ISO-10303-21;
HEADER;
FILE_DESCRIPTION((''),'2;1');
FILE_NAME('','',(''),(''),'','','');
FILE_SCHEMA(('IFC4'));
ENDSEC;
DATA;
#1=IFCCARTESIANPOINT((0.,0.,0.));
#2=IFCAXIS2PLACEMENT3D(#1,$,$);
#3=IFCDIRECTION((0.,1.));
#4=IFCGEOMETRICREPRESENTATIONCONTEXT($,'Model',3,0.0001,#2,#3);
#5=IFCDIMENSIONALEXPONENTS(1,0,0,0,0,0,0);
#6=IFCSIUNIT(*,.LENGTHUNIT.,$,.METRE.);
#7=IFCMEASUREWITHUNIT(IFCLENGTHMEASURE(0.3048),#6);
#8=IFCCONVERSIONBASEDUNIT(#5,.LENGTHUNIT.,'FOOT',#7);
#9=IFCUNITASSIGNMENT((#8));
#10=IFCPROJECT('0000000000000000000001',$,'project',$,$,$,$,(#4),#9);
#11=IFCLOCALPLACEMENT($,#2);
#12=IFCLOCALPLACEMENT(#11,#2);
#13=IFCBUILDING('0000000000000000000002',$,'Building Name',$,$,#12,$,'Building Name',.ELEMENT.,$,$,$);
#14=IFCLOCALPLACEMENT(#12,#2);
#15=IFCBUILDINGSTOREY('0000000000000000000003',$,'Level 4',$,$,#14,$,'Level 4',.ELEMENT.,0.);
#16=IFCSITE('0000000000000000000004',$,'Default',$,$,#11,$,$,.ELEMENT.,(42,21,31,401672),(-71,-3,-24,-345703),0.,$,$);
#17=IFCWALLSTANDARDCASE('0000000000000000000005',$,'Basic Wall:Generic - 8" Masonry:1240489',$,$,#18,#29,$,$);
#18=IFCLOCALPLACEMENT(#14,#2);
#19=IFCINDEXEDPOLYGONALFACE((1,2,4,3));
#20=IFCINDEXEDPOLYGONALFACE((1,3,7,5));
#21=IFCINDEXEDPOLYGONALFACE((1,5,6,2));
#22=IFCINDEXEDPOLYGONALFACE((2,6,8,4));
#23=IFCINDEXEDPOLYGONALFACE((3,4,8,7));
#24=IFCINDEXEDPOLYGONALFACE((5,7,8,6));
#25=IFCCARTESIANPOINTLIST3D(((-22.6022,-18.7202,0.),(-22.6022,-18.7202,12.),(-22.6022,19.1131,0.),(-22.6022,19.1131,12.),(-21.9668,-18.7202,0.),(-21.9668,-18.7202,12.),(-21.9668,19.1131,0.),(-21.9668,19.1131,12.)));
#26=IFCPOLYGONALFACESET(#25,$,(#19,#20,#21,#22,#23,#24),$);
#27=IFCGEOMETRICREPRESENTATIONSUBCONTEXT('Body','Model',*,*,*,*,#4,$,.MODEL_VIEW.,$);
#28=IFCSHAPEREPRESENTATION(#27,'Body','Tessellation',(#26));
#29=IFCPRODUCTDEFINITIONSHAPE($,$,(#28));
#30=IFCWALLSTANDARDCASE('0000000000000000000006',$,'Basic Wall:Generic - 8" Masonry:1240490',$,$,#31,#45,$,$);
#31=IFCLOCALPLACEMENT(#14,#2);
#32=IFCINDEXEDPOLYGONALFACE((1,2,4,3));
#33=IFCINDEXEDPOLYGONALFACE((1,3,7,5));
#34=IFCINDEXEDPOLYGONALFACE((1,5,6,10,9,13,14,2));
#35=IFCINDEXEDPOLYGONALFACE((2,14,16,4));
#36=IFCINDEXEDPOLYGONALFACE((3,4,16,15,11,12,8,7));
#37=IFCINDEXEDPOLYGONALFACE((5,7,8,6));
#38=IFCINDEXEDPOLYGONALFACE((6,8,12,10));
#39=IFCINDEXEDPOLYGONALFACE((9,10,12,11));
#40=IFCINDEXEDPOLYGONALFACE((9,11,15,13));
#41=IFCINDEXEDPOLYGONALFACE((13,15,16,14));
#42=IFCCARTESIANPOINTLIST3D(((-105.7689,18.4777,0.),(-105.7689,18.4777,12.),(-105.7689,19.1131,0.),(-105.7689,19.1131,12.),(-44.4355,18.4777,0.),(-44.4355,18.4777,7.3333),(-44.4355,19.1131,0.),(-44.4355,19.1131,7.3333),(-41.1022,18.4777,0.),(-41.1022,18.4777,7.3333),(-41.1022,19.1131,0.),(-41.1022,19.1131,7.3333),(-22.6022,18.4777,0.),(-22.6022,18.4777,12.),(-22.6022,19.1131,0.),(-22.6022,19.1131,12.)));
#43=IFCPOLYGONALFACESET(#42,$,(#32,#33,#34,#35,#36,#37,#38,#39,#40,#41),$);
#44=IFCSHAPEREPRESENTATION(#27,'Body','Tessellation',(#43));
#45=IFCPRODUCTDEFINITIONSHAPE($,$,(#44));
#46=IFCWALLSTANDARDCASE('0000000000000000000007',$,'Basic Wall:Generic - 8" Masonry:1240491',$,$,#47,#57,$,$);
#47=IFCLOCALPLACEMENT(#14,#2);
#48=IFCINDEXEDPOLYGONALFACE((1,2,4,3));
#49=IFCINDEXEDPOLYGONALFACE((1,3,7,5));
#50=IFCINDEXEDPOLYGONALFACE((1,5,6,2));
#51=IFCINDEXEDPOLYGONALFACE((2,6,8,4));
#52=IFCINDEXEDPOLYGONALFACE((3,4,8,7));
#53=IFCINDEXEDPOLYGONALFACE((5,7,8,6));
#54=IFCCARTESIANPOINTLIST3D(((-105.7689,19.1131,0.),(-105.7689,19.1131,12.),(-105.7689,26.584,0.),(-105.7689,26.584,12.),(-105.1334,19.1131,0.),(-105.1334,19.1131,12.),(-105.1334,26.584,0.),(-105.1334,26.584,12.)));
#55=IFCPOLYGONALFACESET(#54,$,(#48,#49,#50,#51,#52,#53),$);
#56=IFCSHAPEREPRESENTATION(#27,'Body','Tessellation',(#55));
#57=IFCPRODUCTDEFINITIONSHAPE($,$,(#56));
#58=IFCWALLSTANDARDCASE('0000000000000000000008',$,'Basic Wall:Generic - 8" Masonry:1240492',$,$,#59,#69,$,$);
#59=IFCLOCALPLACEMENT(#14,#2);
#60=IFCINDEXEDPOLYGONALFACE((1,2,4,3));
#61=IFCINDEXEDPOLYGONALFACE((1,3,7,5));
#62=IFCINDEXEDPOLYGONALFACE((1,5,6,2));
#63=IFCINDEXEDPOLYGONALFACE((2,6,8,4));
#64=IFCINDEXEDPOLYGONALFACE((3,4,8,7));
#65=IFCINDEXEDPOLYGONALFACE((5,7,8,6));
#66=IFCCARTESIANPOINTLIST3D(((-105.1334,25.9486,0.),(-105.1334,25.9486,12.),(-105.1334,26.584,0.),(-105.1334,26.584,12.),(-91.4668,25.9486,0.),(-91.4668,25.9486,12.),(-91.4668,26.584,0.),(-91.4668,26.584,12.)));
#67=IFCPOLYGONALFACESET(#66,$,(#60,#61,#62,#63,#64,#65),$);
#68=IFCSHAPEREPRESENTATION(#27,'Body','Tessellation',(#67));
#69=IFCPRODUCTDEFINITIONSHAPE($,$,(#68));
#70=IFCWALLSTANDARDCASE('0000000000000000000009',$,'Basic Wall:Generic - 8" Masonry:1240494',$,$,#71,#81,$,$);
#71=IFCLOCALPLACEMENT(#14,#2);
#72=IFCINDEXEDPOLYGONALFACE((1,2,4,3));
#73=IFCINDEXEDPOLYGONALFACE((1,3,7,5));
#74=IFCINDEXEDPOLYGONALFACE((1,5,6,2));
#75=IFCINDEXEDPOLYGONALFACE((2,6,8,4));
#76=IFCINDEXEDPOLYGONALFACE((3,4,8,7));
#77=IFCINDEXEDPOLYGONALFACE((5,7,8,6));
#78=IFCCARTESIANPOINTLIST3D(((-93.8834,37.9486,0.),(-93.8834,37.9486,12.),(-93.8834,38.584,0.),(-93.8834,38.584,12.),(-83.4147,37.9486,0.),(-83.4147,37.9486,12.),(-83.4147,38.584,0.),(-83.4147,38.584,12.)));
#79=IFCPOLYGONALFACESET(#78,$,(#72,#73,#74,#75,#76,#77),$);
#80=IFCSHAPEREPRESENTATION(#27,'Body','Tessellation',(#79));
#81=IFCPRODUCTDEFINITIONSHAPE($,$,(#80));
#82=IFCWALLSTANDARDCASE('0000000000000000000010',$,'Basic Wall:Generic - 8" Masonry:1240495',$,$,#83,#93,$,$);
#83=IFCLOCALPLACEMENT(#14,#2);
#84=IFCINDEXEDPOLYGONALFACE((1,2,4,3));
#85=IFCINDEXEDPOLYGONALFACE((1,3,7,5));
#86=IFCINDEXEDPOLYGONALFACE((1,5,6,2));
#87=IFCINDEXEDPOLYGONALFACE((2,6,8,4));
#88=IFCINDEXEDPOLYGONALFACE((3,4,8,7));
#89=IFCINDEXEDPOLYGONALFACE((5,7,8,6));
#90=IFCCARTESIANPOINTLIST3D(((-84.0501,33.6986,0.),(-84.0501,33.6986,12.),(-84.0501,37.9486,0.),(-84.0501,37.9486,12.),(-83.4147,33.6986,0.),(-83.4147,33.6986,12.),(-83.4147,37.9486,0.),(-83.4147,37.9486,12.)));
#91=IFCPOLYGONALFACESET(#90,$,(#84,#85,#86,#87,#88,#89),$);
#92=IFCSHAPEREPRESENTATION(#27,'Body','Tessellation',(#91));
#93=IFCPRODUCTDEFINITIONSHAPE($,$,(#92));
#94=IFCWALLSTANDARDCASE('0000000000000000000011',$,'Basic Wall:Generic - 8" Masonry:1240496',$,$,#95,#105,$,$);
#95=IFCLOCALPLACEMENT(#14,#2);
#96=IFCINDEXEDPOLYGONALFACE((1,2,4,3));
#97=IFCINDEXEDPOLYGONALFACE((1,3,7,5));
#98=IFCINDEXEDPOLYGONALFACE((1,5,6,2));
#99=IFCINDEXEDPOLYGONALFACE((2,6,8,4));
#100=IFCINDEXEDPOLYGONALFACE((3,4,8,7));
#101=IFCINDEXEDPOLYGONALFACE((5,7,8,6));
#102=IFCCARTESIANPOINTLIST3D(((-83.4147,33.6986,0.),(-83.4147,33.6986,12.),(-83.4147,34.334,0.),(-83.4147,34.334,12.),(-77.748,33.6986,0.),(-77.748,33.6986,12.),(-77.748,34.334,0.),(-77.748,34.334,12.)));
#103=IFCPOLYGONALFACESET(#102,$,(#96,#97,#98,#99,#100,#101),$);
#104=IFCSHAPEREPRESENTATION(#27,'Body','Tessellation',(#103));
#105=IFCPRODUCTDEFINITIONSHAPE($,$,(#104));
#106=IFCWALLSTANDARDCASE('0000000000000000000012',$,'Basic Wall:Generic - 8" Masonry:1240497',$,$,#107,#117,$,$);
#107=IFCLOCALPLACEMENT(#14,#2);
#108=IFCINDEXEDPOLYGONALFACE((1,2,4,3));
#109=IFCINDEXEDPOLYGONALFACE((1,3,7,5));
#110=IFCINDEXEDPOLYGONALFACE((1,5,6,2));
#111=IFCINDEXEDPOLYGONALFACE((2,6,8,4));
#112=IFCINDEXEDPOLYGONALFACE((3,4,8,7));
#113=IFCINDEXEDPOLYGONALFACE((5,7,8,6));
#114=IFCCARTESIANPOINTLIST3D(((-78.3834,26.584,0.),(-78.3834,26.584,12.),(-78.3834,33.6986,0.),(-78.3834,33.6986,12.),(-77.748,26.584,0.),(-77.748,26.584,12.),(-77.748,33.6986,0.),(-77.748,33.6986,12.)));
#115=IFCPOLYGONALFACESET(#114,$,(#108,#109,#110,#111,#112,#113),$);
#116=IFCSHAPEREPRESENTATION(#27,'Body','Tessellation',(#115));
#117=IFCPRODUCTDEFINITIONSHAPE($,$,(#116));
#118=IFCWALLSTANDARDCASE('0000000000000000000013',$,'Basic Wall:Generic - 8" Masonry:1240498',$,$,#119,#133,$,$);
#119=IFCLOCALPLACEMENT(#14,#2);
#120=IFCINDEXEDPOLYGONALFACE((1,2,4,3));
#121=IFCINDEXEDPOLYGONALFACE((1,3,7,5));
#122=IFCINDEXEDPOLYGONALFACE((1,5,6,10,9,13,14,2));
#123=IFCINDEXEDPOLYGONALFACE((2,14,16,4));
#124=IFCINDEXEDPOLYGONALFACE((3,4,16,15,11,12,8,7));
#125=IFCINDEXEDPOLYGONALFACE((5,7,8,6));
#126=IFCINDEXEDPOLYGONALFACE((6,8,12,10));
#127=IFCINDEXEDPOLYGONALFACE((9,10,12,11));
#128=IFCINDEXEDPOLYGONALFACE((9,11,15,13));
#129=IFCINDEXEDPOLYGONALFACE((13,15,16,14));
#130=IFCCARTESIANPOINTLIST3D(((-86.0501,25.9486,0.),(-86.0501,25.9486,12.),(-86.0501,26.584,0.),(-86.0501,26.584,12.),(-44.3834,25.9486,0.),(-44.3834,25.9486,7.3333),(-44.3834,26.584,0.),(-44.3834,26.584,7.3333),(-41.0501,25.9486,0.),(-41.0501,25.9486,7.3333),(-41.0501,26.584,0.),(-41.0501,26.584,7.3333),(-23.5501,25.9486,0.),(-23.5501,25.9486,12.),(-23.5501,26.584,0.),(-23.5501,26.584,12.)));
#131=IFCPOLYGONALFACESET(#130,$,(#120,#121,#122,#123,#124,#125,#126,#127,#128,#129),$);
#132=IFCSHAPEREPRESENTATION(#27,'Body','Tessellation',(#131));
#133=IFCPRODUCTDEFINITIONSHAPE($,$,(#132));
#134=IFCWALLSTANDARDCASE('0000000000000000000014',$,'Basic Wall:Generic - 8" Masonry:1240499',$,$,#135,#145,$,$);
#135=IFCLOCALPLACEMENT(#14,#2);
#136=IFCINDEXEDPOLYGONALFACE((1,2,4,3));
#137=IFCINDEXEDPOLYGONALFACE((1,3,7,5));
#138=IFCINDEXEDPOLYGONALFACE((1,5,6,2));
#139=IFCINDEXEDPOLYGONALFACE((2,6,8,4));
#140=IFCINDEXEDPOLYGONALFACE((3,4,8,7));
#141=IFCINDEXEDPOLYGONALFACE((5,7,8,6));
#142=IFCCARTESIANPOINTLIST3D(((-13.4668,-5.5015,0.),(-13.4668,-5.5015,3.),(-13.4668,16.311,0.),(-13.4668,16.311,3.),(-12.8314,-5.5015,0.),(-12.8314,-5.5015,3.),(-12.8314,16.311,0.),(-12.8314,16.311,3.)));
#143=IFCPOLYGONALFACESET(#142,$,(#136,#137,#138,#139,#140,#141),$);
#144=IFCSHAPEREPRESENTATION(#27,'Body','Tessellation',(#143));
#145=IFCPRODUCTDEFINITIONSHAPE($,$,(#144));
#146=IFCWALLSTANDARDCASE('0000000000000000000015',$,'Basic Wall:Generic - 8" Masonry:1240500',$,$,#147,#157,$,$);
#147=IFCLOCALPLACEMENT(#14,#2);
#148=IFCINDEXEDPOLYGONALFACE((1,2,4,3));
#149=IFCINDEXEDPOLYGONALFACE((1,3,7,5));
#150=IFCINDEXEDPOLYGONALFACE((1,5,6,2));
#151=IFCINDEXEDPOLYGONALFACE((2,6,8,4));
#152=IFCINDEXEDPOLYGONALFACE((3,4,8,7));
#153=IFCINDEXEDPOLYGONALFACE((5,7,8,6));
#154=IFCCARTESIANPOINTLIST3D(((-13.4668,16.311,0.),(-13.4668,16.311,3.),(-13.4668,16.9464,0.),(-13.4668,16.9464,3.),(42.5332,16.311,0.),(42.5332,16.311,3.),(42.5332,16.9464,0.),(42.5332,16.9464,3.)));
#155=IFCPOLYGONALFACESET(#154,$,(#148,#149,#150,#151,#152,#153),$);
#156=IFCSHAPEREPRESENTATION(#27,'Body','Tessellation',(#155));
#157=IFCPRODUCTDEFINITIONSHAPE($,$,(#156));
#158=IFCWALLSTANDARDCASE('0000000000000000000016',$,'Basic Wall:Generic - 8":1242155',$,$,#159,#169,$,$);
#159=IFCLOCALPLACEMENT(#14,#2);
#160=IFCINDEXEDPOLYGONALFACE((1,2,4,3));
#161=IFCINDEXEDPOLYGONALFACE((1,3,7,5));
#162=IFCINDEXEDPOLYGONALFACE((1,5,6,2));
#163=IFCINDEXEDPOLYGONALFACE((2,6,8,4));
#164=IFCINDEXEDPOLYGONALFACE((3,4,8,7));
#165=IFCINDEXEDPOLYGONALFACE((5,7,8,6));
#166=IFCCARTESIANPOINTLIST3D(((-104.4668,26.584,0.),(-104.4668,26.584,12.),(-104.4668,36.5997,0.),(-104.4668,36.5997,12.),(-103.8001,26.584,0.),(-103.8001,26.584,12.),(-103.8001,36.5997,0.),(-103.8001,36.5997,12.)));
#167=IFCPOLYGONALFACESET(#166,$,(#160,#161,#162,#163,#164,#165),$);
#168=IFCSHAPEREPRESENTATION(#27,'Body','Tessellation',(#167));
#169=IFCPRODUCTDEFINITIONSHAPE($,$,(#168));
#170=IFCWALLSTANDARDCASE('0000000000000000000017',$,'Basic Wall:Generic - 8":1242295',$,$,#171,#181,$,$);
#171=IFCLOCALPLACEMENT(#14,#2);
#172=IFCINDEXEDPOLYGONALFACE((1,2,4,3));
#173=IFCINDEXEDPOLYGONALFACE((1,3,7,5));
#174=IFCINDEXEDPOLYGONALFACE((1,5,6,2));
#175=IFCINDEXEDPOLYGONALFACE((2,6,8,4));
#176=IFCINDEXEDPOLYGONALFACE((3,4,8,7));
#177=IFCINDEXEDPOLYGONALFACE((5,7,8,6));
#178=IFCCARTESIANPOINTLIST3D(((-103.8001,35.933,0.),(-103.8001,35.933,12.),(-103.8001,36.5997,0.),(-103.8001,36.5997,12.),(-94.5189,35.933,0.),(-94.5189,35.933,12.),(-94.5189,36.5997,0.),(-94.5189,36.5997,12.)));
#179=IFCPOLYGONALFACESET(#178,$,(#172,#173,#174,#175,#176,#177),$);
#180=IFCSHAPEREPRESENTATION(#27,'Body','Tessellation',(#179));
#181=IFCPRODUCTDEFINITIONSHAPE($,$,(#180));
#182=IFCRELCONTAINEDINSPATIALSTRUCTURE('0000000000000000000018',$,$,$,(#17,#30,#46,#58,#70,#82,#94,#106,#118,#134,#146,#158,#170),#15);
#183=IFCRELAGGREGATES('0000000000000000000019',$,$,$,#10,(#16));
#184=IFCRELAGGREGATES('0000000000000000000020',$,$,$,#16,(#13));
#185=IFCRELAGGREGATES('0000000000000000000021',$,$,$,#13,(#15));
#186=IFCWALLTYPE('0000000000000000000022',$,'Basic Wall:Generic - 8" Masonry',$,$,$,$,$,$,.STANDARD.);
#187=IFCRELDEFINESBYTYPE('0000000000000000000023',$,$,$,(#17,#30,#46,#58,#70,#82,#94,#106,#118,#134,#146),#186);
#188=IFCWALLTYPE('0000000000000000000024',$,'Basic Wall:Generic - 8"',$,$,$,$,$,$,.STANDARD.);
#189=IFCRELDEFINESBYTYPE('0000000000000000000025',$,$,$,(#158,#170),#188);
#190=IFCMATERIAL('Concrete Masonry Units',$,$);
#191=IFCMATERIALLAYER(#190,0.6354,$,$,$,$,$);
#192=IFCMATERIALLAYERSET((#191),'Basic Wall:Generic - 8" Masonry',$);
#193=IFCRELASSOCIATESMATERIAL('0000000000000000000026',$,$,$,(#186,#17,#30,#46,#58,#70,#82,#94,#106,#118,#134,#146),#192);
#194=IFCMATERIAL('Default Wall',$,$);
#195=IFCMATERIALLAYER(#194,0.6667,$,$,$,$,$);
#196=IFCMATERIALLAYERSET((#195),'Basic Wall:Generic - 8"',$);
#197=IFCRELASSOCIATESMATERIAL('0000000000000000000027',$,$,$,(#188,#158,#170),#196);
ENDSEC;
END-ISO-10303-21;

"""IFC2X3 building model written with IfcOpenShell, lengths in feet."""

from ifc_helpers import new_model, entity, si_unit, converted_unit, direction, frame, frame_2d, origin, place, context, subcontext, project, spatial, rectangle, extrude, material, layer, layer_set, layer_usage, type_object, element, save


model = new_model("IFC2X3")

# Units and contexts
model_context = context("Model", 3, precision=0.0001, world=origin(), true_north=direction((0.0, 1.0)))
body_context = subcontext(model_context, "Body", "Model", "MODEL_VIEW")
ifc_project = project(units=[converted_unit("LENGTHUNIT", "FOOT", entity("IfcLengthMeasure", 0.3048), si_unit("LENGTHUNIT", "METRE"), dimensions=[1, 0, 0, 0, 0, 0, 0])], contexts=[model_context])

# Site, building, storey
site_placement = place(None, origin())
site = spatial("IfcSite", under=ifc_project, at=site_placement, Name="Default", CompositionType="ELEMENT", RefLatitude=(42, 21, 31, 401672), RefLongitude=(-71, -3, -24, -345703), RefElevation=0.0)
building_placement = place(site_placement, origin())
building = spatial("IfcBuilding", under=site, at=building_placement, Name="Building Name", LongName="Building Name", CompositionType="ELEMENT")
storey_placement = place(building_placement, origin())
storey = spatial("IfcBuildingStorey", under=building, at=storey_placement, Name="Level 4", LongName="Level 4", CompositionType="ELEMENT", Elevation=0.0)

# Wall
ifc_material_1 = material(Name="Concrete Masonry Units")
ifc_layer_1 = layer(ifc_material_1, 0.6354)
ifc_layer_set_1 = layer_set([ifc_layer_1], Name="Basic Wall:Generic - 8\" Masonry")
ifc_layer_usage_1 = layer_usage(ifc_layer_set_1, "AXIS2", "NEGATIVE", 0.3177)
wall_type_1 = type_object("IfcWallType", Name="Basic Wall:Generic - 8\" Masonry", PredefinedType="STANDARD", material=ifc_layer_set_1)
wall_1_placement = place(storey_placement, frame((-22.2845, 19.1131, 0.0), z_axis=(0.0, 0.0, 1.0), x_axis=(0.0, -1.0, 0.0)))
element("IfcWallStandardCase", 1, at=wall_1_placement, inside=storey, type_object=wall_type_1, material=ifc_layer_usage_1, Name="Basic Wall:Generic - 8\" Masonry:1240489", context=body_context, shape_type="SweptSolid", body=[
    extrude(rectangle(XDim=37.8333, YDim=0.6354, at=frame_2d((18.9167, 0.0), x_axis=(-1.0, 0.0))), origin(), (0.0, 0.0, 1.0), 12.0),
])

# Wall, opening
ifc_layer_usage_2 = layer_usage(ifc_layer_set_1, "AXIS2", "NEGATIVE", 0.3177)
wall_2_placement = place(storey_placement, frame((-22.6022, 18.7954, 0.0), z_axis=(0.0, 0.0, 1.0), x_axis=(-1.0, 0.0, 0.0)))
wall_2 = element("IfcWallStandardCase", 2, at=wall_2_placement, inside=storey, type_object=wall_type_1, material=ifc_layer_usage_2, Name="Basic Wall:Generic - 8\" Masonry:1240490", context=body_context, shape_type="SweptSolid", body=[
    extrude(rectangle(XDim=83.1667, YDim=0.6354, at=frame_2d((41.5833, 0.0), x_axis=(1.0, 0.0))), origin(), (0.0, 0.0, 1.0), 12.0),
])
opening_1_placement = place(wall_2_placement, frame((18.5, -0.3177, 0.0)))
element("IfcOpeningElement", 3, at=opening_1_placement, cuts=wall_2, ObjectType="Opening", context=body_context, shape_type="SweptSolid", body=[
    extrude(rectangle(XDim=7.3333, YDim=3.3333, at=frame_2d((3.6667, 1.6667), x_axis=(1.0, 0.0))), frame((0.0, 0.0, 0.0), z_axis=(0.0, 1.0, 0.0), x_axis=(0.0, 0.0, 1.0)), (0.0, 0.0, 1.0), 0.6354),
])

# Walls
ifc_layer_usage_3 = layer_usage(ifc_layer_set_1, "AXIS2", "NEGATIVE", 0.3177)
wall_3_placement = place(storey_placement, frame((-105.4511, 19.1131, 0.0), z_axis=(0.0, 0.0, 1.0), x_axis=(0.0, 1.0, 0.0)))
element("IfcWallStandardCase", 4, at=wall_3_placement, inside=storey, type_object=wall_type_1, material=ifc_layer_usage_3, Name="Basic Wall:Generic - 8\" Masonry:1240491", context=body_context, shape_type="SweptSolid", body=[
    extrude(rectangle(XDim=7.4709, YDim=0.6354, at=frame_2d((3.7355, 0.0), x_axis=(-1.0, 0.0))), origin(), (0.0, 0.0, 1.0), 12.0),
])
ifc_layer_usage_4 = layer_usage(ifc_layer_set_1, "AXIS2", "NEGATIVE", 0.3177)
wall_4_placement = place(storey_placement, frame((-105.1334, 26.2663, 0.0)))
element("IfcWallStandardCase", 5, at=wall_4_placement, inside=storey, type_object=wall_type_1, material=ifc_layer_usage_4, Name="Basic Wall:Generic - 8\" Masonry:1240492", context=body_context, shape_type="SweptSolid", body=[
    extrude(rectangle(XDim=13.6667, YDim=0.6354, at=frame_2d((6.8333, 0.0), x_axis=(-1.0, 0.0))), origin(), (0.0, 0.0, 1.0), 12.0),
])

# Walls
ifc_layer_usage_5 = layer_usage(ifc_layer_set_1, "AXIS2", "NEGATIVE", 0.3177)
wall_5_placement = place(storey_placement, frame((-93.8834, 38.2663, 0.0)))
element("IfcWallStandardCase", 6, at=wall_5_placement, inside=storey, type_object=wall_type_1, material=ifc_layer_usage_5, Name="Basic Wall:Generic - 8\" Masonry:1240494", context=body_context, shape_type="SweptSolid", body=[
    extrude(rectangle(XDim=10.4687, YDim=0.6354, at=frame_2d((5.2344, 0.0), x_axis=(-1.0, 0.0))), origin(), (0.0, 0.0, 1.0), 12.0),
])
ifc_layer_usage_6 = layer_usage(ifc_layer_set_1, "AXIS2", "NEGATIVE", 0.3177)
wall_6_placement = place(storey_placement, frame((-83.7324, 37.9486, 0.0), z_axis=(0.0, 0.0, 1.0), x_axis=(0.0, -1.0, 0.0)))
element("IfcWallStandardCase", 7, at=wall_6_placement, inside=storey, type_object=wall_type_1, material=ifc_layer_usage_6, Name="Basic Wall:Generic - 8\" Masonry:1240495", context=body_context, shape_type="SweptSolid", body=[
    extrude(rectangle(XDim=4.25, YDim=0.6354, at=frame_2d((2.125, 0.0), x_axis=(-1.0, 0.0))), origin(), (0.0, 0.0, 1.0), 12.0),
])
ifc_layer_usage_7 = layer_usage(ifc_layer_set_1, "AXIS2", "NEGATIVE", 0.3177)
wall_7_placement = place(storey_placement, frame((-83.4147, 34.0163, 0.0)))
element("IfcWallStandardCase", 8, at=wall_7_placement, inside=storey, type_object=wall_type_1, material=ifc_layer_usage_7, Name="Basic Wall:Generic - 8\" Masonry:1240496", context=body_context, shape_type="SweptSolid", body=[
    extrude(rectangle(XDim=5.6667, YDim=0.6354, at=frame_2d((2.8333, 0.0), x_axis=(-1.0, 0.0))), origin(), (0.0, 0.0, 1.0), 12.0),
])
ifc_layer_usage_8 = layer_usage(ifc_layer_set_1, "AXIS2", "NEGATIVE", 0.3177)
wall_8_placement = place(storey_placement, frame((-78.0657, 33.6986, 0.0), z_axis=(0.0, 0.0, 1.0), x_axis=(0.0, -1.0, 0.0)))
element("IfcWallStandardCase", 9, at=wall_8_placement, inside=storey, type_object=wall_type_1, material=ifc_layer_usage_8, Name="Basic Wall:Generic - 8\" Masonry:1240497", context=body_context, shape_type="SweptSolid", body=[
    extrude(rectangle(XDim=7.1146, YDim=0.6354, at=frame_2d((3.5573, 0.0), x_axis=(1.0, 0.0))), origin(), (0.0, 0.0, 1.0), 12.0),
])

# Wall, opening
ifc_layer_usage_9 = layer_usage(ifc_layer_set_1, "AXIS2", "NEGATIVE", 0.3177)
wall_9_placement = place(storey_placement, frame((-23.5501, 26.2663, 0.0), z_axis=(0.0, 0.0, 1.0), x_axis=(-1.0, 0.0, 0.0)))
wall_9 = element("IfcWallStandardCase", 10, at=wall_9_placement, inside=storey, type_object=wall_type_1, material=ifc_layer_usage_9, Name="Basic Wall:Generic - 8\" Masonry:1240498", context=body_context, shape_type="SweptSolid", body=[
    extrude(rectangle(XDim=62.5, YDim=0.6354, at=frame_2d((31.25, 0.0), x_axis=(1.0, 0.0))), origin(), (0.0, 0.0, 1.0), 12.0),
])
opening_2_placement = place(wall_9_placement, frame((20.8333, 0.3177, 0.0)))
element("IfcOpeningElement", 11, at=opening_2_placement, cuts=wall_9, ObjectType="Opening", context=body_context, shape_type="SweptSolid", body=[
    extrude(rectangle(XDim=7.3333, YDim=3.3333, at=frame_2d((3.6667, 1.6667), x_axis=(1.0, 0.0))), frame((0.0, 0.0, 0.0), z_axis=(0.0, -1.0, 0.0), x_axis=(0.0, 0.0, 1.0)), (0.0, 0.0, 1.0), 0.6354),
])

# Walls
ifc_layer_usage_10 = layer_usage(ifc_layer_set_1, "AXIS2", "NEGATIVE", 0.3177)
wall_10_placement = place(storey_placement, frame((-13.1491, -5.5015, 0.0), z_axis=(0.0, 0.0, 1.0), x_axis=(0.0, 1.0, 0.0)))
element("IfcWallStandardCase", 12, at=wall_10_placement, inside=storey, type_object=wall_type_1, material=ifc_layer_usage_10, Name="Basic Wall:Generic - 8\" Masonry:1240499", context=body_context, shape_type="SweptSolid", body=[
    extrude(rectangle(XDim=21.8125, YDim=0.6354, at=frame_2d((10.9063, 0.0), x_axis=(-1.0, 0.0))), origin(), (0.0, 0.0, 1.0), 3.0),
])
ifc_layer_usage_11 = layer_usage(ifc_layer_set_1, "AXIS2", "NEGATIVE", 0.3177)
wall_11_placement = place(storey_placement, frame((-13.4668, 16.6287, 0.0)))
element("IfcWallStandardCase", 13, at=wall_11_placement, inside=storey, type_object=wall_type_1, material=ifc_layer_usage_11, Name="Basic Wall:Generic - 8\" Masonry:1240500", context=body_context, shape_type="SweptSolid", body=[
    extrude(rectangle(XDim=56.0, YDim=0.6354, at=frame_2d((28.0, 0.0), x_axis=(-1.0, 0.0))), origin(), (0.0, 0.0, 1.0), 3.0),
])
ifc_material_2 = material(Name="Default Wall")
ifc_layer_2 = layer(ifc_material_2, 0.6667)
ifc_layer_set_2 = layer_set([ifc_layer_2], Name="Basic Wall:Generic - 8\"")
ifc_layer_usage_12 = layer_usage(ifc_layer_set_2, "AXIS2", "NEGATIVE", 0.3333)
wall_type_2 = type_object("IfcWallType", Name="Basic Wall:Generic - 8\"", PredefinedType="STANDARD", material=ifc_layer_set_2)
wall_12_placement = place(storey_placement, frame((-104.1334, 26.584, 0.0), z_axis=(0.0, 0.0, 1.0), x_axis=(0.0, 1.0, 0.0)))
element("IfcWallStandardCase", 14, at=wall_12_placement, inside=storey, type_object=wall_type_2, material=ifc_layer_usage_12, Name="Basic Wall:Generic - 8\":1242155", context=body_context, shape_type="SweptSolid", body=[
    extrude(rectangle(XDim=10.0156, YDim=0.6667, at=frame_2d((5.0078, 0.0), x_axis=(-1.0, 0.0))), origin(), (0.0, 0.0, 1.0), 12.0),
])
ifc_layer_usage_13 = layer_usage(ifc_layer_set_2, "AXIS2", "POSITIVE", -0.3333)
wall_13_placement = place(storey_placement, frame((-103.8001, 36.2663, 0.0)))
element("IfcWallStandardCase", 15, at=wall_13_placement, inside=storey, type_object=wall_type_2, material=ifc_layer_usage_13, Name="Basic Wall:Generic - 8\":1242295", context=body_context, shape_type="SweptSolid", body=[
    extrude(rectangle(XDim=9.2812, YDim=0.6667, at=frame_2d((4.6406, 0.0), x_axis=(-1.0, 0.0))), origin(), (0.0, 0.0, 1.0), 12.0),
])

save(model, "model.ifc")
